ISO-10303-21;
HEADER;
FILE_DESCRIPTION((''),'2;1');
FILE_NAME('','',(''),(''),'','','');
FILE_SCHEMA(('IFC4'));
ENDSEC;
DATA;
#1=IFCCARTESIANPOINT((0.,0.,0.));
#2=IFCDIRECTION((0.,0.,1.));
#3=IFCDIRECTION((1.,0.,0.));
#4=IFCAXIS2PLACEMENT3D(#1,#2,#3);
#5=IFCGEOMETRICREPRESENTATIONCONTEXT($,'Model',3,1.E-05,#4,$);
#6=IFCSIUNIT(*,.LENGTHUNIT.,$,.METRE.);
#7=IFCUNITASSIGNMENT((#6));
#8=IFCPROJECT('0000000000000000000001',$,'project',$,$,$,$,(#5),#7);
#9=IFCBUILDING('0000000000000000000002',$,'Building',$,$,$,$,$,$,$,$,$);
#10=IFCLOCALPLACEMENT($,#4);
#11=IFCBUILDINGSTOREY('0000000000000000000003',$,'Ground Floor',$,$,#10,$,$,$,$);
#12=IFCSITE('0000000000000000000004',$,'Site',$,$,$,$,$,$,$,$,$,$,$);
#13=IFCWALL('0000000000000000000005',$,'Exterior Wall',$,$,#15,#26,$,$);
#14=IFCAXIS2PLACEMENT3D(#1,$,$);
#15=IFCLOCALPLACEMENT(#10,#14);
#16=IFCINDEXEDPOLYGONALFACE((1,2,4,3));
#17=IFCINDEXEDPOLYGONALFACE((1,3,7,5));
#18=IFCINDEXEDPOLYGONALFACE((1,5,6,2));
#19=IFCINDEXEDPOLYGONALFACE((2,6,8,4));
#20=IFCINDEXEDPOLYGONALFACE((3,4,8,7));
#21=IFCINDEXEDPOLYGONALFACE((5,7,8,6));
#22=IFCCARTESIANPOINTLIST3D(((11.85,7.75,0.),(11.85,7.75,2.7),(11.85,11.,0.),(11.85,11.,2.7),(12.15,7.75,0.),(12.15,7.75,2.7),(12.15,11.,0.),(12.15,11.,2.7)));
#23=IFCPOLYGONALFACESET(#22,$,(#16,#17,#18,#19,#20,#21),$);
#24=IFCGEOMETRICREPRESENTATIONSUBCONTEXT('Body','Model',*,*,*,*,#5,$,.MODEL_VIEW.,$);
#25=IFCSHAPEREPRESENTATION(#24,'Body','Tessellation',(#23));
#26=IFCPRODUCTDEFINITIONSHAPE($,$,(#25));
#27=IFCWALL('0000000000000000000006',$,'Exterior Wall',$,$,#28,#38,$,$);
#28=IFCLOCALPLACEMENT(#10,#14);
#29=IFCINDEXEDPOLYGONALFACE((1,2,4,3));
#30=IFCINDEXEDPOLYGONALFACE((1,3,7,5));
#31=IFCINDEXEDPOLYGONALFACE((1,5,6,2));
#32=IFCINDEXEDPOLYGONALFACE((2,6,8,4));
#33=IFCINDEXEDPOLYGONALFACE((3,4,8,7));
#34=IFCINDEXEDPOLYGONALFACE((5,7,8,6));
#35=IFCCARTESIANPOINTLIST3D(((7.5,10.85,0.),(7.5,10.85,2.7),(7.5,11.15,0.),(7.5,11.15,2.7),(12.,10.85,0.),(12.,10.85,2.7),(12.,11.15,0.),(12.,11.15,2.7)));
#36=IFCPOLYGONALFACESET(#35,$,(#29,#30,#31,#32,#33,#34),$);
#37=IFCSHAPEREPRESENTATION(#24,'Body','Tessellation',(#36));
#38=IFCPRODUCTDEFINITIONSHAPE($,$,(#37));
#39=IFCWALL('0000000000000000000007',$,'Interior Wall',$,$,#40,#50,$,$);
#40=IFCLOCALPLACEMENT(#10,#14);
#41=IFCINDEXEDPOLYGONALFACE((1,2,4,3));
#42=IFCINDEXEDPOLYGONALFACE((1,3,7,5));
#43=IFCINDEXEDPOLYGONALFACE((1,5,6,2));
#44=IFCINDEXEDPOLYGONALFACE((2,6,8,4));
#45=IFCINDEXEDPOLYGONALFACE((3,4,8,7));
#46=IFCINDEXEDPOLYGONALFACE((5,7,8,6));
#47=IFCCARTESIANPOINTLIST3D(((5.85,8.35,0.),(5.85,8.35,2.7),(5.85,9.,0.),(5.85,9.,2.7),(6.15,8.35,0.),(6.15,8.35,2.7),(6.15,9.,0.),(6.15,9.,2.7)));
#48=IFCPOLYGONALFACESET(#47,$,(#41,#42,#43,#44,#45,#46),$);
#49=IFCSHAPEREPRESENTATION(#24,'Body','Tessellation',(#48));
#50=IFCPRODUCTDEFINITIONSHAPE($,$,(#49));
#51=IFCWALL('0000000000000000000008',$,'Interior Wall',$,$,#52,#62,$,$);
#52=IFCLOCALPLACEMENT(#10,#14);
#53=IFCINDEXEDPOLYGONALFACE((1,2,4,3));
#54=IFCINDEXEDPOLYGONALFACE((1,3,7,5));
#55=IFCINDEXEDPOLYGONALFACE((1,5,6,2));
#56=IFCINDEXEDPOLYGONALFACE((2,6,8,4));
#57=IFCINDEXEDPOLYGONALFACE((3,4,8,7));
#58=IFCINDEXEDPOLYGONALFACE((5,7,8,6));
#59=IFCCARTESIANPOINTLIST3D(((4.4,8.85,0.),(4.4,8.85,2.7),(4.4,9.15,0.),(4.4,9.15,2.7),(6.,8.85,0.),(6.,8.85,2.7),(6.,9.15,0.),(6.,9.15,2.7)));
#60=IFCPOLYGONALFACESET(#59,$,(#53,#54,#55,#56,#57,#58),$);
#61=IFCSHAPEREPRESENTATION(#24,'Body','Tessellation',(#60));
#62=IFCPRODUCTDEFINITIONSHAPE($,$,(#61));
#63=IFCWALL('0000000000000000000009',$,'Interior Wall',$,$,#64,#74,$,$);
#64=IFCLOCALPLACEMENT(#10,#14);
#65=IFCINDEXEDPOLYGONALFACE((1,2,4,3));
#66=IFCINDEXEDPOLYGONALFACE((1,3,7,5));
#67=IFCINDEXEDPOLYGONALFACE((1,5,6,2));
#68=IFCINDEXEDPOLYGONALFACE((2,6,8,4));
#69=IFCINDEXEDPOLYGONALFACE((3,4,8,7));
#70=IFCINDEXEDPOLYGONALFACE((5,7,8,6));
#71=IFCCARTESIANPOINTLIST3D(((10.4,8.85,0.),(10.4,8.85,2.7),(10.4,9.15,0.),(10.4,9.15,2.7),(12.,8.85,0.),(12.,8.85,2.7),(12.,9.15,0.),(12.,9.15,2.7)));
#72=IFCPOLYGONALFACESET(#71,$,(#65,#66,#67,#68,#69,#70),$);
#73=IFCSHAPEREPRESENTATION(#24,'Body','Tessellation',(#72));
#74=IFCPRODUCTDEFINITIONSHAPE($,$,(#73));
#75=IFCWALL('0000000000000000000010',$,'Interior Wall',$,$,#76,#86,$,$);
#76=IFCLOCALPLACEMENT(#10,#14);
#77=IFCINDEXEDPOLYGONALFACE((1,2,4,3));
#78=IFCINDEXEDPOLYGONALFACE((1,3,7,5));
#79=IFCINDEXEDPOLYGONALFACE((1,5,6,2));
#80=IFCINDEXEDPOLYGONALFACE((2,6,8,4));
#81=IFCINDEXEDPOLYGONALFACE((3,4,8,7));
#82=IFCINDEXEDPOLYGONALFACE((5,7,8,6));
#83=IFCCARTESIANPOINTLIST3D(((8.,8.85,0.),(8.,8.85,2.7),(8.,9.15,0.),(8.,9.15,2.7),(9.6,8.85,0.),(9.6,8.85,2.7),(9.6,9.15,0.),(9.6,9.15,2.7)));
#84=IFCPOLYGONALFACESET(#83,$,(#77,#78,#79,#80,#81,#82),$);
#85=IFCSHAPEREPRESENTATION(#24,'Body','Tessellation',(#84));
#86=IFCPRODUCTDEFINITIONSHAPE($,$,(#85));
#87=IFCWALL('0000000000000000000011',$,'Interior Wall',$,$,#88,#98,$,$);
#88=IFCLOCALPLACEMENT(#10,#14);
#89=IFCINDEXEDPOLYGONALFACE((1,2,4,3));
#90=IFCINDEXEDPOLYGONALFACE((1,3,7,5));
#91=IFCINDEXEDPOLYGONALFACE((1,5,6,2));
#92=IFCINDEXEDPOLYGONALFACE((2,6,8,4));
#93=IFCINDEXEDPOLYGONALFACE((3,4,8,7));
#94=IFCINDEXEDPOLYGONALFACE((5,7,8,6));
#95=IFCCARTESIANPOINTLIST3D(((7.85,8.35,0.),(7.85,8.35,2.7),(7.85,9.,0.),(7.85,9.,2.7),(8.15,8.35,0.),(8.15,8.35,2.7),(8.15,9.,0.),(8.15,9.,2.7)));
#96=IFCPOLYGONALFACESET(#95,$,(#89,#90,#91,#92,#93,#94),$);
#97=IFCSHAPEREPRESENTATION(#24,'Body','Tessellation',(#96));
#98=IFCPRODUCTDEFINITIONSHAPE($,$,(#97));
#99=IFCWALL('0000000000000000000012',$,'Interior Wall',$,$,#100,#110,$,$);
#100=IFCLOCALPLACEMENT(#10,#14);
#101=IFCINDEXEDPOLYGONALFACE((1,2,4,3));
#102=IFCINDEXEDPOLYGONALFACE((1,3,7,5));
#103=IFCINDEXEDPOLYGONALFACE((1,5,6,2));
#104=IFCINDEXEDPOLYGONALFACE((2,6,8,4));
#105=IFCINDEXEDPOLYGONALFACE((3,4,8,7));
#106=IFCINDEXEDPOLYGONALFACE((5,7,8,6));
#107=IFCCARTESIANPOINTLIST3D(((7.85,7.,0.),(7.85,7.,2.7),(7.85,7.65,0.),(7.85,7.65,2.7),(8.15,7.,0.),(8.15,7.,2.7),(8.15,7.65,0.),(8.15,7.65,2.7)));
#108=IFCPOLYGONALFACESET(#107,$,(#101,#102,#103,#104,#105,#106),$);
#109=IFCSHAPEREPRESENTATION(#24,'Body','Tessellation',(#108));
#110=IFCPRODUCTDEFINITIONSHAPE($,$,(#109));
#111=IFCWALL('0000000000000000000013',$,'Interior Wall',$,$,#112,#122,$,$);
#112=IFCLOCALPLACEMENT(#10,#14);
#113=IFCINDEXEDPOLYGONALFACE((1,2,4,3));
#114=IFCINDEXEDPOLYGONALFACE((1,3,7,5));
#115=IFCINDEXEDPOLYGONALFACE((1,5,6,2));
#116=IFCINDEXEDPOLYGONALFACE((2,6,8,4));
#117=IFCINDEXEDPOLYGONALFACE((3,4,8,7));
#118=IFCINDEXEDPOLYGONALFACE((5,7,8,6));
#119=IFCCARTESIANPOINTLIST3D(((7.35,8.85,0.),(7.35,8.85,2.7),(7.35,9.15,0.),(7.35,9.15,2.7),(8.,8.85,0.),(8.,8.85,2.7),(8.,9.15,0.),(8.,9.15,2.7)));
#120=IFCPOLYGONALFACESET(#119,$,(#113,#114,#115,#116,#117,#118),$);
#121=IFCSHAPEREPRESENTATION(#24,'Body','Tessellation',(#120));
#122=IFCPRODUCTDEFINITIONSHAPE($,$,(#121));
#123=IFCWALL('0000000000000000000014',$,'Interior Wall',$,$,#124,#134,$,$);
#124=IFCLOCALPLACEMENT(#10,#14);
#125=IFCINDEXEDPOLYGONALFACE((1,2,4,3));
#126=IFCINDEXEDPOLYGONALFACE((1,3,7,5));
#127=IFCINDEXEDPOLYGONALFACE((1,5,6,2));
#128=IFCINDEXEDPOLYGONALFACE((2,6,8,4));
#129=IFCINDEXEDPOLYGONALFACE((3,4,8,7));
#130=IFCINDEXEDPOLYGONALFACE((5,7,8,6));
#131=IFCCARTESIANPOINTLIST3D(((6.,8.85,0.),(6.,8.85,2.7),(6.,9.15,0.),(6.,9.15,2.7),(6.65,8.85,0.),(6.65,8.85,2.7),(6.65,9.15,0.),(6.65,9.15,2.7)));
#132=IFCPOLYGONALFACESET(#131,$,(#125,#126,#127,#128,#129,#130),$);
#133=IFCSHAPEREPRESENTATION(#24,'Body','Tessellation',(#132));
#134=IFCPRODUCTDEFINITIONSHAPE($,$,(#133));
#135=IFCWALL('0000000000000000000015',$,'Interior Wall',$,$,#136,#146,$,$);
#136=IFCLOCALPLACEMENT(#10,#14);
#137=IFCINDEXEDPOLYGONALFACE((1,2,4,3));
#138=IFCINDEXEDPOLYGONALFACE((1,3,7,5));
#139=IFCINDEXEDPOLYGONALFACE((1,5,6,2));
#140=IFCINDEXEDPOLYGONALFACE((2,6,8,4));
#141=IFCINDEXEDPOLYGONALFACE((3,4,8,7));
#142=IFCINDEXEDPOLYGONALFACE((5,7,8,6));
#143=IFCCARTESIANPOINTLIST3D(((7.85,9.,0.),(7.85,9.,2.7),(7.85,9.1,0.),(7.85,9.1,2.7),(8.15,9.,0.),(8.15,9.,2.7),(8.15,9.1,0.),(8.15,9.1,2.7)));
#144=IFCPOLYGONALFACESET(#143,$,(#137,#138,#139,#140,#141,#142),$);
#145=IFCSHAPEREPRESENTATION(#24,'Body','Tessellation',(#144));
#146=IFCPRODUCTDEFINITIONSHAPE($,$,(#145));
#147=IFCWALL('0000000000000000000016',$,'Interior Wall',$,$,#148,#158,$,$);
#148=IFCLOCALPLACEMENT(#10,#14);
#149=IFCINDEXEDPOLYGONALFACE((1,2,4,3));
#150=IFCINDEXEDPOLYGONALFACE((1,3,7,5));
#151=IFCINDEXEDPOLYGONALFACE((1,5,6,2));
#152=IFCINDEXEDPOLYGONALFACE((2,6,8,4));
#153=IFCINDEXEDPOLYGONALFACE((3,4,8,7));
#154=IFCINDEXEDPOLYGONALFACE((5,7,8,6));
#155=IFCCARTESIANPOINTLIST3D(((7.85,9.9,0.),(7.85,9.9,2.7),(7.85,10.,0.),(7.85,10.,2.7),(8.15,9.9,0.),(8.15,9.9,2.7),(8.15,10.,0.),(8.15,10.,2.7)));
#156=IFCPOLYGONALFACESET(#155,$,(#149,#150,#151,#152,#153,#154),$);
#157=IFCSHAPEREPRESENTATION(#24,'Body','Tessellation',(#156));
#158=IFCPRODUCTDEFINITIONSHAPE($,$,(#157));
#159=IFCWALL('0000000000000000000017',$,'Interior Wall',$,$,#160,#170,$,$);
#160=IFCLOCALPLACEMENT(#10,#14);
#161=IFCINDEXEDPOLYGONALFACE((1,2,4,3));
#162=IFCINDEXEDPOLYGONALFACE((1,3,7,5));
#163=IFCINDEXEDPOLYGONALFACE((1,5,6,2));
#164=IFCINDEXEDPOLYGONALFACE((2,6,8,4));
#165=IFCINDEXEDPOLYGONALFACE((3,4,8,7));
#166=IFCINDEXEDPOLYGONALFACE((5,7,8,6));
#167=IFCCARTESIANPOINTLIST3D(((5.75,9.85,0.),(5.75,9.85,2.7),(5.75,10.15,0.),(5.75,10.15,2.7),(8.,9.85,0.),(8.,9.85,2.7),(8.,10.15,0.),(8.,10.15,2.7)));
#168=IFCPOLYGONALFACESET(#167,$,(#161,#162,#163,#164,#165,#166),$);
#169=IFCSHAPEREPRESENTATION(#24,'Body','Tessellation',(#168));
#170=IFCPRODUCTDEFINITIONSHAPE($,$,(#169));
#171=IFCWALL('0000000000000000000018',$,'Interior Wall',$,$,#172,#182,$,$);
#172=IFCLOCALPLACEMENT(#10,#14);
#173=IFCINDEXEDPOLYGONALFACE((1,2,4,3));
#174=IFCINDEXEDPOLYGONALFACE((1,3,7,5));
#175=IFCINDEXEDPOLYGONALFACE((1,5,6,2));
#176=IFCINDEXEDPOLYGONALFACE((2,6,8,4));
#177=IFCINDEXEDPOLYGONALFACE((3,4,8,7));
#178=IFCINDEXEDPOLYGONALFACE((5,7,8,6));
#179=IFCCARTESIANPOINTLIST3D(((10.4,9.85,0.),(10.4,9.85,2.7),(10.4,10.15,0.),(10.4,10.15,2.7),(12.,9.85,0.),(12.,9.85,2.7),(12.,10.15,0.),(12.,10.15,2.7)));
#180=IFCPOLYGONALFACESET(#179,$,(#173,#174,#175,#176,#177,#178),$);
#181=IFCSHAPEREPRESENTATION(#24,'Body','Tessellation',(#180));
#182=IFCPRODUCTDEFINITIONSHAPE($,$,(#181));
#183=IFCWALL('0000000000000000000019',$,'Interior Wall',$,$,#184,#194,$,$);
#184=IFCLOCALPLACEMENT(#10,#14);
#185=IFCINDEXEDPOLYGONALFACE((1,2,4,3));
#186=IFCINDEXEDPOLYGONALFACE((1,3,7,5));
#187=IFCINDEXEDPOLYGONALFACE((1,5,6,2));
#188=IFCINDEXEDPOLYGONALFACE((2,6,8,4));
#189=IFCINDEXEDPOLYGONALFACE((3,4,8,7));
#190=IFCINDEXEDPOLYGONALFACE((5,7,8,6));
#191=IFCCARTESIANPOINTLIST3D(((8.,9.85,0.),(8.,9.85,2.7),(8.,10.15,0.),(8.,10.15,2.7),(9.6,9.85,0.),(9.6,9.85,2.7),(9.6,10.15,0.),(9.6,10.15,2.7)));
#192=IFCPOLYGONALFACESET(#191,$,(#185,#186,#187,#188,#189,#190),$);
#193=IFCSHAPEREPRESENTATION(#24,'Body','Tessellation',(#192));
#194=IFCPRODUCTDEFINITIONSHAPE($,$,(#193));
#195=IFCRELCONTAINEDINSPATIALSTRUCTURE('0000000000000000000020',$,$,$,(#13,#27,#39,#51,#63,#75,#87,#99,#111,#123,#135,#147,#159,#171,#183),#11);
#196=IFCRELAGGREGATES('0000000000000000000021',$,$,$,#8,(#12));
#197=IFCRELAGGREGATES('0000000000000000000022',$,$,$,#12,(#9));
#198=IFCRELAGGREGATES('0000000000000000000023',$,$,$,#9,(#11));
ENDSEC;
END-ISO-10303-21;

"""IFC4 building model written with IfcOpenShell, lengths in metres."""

from ifc_helpers import new_model, si_unit, frame, origin_with_axes, place, context, subcontext, project, spatial, indexed_curve, outline, extrude, element, save


model = new_model("IFC4")

# Units and contexts
model_context = context("Model", 3, precision=1e-05, world=origin_with_axes())
body_context = subcontext(model_context, "Body", "Model", "MODEL_VIEW")
ifc_project = project(units=[si_unit("LENGTHUNIT", "METRE")], contexts=[model_context])

# Site, building, storey
site = spatial("IfcSite", under=ifc_project, Name="Site")
building = spatial("IfcBuilding", under=site, Name="Building")
storey_placement = place(None, origin_with_axes())
storey = spatial("IfcBuildingStorey", under=building, at=storey_placement, Name="Ground Floor")

# Walls
wall_1_placement = place(storey_placement, frame((12.0, 7.75, 0.0), z_axis=(0.0, 0.0, 1.0), x_axis=(0.0, 1.0, 0.0)))
element("IfcWall", 1, at=wall_1_placement, inside=storey, Name="Exterior Wall", context=body_context, shape_type="SweptSolid", body=[
    extrude(outline(indexed_curve([(0.0, 0.0), (0.0, 0.3), (3.25, 0.3), (3.25, 0.0), (0.0, 0.0)], self_intersect=False)), frame((0.0, -0.15, 0.0), z_axis=(0.0, 0.0, 1.0), x_axis=(1.0, 0.0, 0.0)), (0.0, 0.0, 1.0), 2.7),
])
wall_2_placement = place(storey_placement, frame((12.0, 11.0, 0.0), z_axis=(0.0, 0.0, 1.0), x_axis=(-1.0, 0.0, 0.0)))
element("IfcWall", 2, at=wall_2_placement, inside=storey, Name="Exterior Wall", context=body_context, shape_type="SweptSolid", body=[
    extrude(outline(indexed_curve([(0.0, 0.0), (0.0, 0.3), (4.5, 0.3), (4.5, 0.0), (0.0, 0.0)], self_intersect=False)), frame((0.0, -0.15, 0.0), z_axis=(0.0, 0.0, 1.0), x_axis=(1.0, 0.0, 0.0)), (0.0, 0.0, 1.0), 2.7),
])
wall_3_placement = place(storey_placement, frame((6.0, 8.35, 0.0), z_axis=(0.0, 0.0, 1.0), x_axis=(0.0, 1.0, 0.0)))
element("IfcWall", 3, at=wall_3_placement, inside=storey, Name="Interior Wall", context=body_context, shape_type="SweptSolid", body=[
    extrude(outline(indexed_curve([(0.0, 0.0), (0.0, 0.3), (0.65, 0.3), (0.65, 0.0), (0.0, 0.0)], self_intersect=False)), frame((0.0, -0.15, 0.0), z_axis=(0.0, 0.0, 1.0), x_axis=(1.0, 0.0, 0.0)), (0.0, 0.0, 1.0), 2.7),
])
for number, where, z_axis, x_axis, name in (
    (4, (6.0, 9.0, 0.0), (0.0, 0.0, 1.0), (-1.0, 0.0, 0.0), "Interior Wall"),
    (5, (12.0, 9.0, 0.0), (0.0, 0.0, 1.0), (-1.0, 0.0, 0.0), "Interior Wall"),
    (6, (9.6, 9.0, 0.0), (0.0, 0.0, 1.0), (-1.0, 0.0, 0.0), "Interior Wall"),
):
    element("IfcWall", number, at=place(storey_placement, frame(where, z_axis=z_axis, x_axis=x_axis)), inside=storey, Name=name, context=body_context, shape_type="SweptSolid", body=[
        extrude(outline(indexed_curve([(0.0, 0.0), (0.0, 0.3), (1.6, 0.3), (1.6, 0.0), (0.0, 0.0)], self_intersect=False)), frame((0.0, -0.15, 0.0), z_axis=(0.0, 0.0, 1.0), x_axis=(1.0, 0.0, 0.0)), (0.0, 0.0, 1.0), 2.7),
    ])
for number, where, z_axis, x_axis, name in (
    (7, (8.0, 9.0, 0.0), (0.0, 0.0, 1.0), (0.0, -1.0, 0.0), "Interior Wall"),
    (8, (8.0, 7.65, 0.0), (0.0, 0.0, 1.0), (0.0, -1.0, 0.0), "Interior Wall"),
    (9, (8.0, 9.0, 0.0), (0.0, 0.0, 1.0), (-1.0, 0.0, 0.0), "Interior Wall"),
    (10, (6.65, 9.0, 0.0), (0.0, 0.0, 1.0), (-1.0, 0.0, 0.0), "Interior Wall"),
):
    element("IfcWall", number, at=place(storey_placement, frame(where, z_axis=z_axis, x_axis=x_axis)), inside=storey, Name=name, context=body_context, shape_type="SweptSolid", body=[
        extrude(outline(indexed_curve([(0.0, 0.0), (0.0, 0.3), (0.65, 0.3), (0.65, 0.0), (0.0, 0.0)], self_intersect=False)), frame((0.0, -0.15, 0.0), z_axis=(0.0, 0.0, 1.0), x_axis=(1.0, 0.0, 0.0)), (0.0, 0.0, 1.0), 2.7),
    ])
for number, where, z_axis, x_axis, name in (
    (11, (8.0, 9.0, 0.0), (0.0, 0.0, 1.0), (0.0, 1.0, 0.0), "Interior Wall"),
    (12, (8.0, 9.9, 0.0), (0.0, 0.0, 1.0), (0.0, 1.0, 0.0), "Interior Wall"),
):
    element("IfcWall", number, at=place(storey_placement, frame(where, z_axis=z_axis, x_axis=x_axis)), inside=storey, Name=name, context=body_context, shape_type="SweptSolid", body=[
        extrude(outline(indexed_curve([(0.0, 0.0), (0.0, 0.3), (0.1, 0.3), (0.1, 0.0), (0.0, 0.0)], self_intersect=False)), frame((0.0, -0.15, 0.0), z_axis=(0.0, 0.0, 1.0), x_axis=(1.0, 0.0, 0.0)), (0.0, 0.0, 1.0), 2.7),
    ])
wall_4_placement = place(storey_placement, frame((8.0, 10.0, 0.0), z_axis=(0.0, 0.0, 1.0), x_axis=(-1.0, 0.0, 0.0)))
element("IfcWall", 13, at=wall_4_placement, inside=storey, Name="Interior Wall", context=body_context, shape_type="SweptSolid", body=[
    extrude(outline(indexed_curve([(0.0, 0.0), (0.0, 0.3), (2.25, 0.3), (2.25, 0.0), (0.0, 0.0)], self_intersect=False)), frame((0.0, -0.15, 0.0), z_axis=(0.0, 0.0, 1.0), x_axis=(1.0, 0.0, 0.0)), (0.0, 0.0, 1.0), 2.7),
])
for number, where, z_axis, x_axis, name in (
    (14, (12.0, 10.0, 0.0), (0.0, 0.0, 1.0), (-1.0, 0.0, 0.0), "Interior Wall"),
    (15, (9.6, 10.0, 0.0), (0.0, 0.0, 1.0), (-1.0, 0.0, 0.0), "Interior Wall"),
):
    element("IfcWall", number, at=place(storey_placement, frame(where, z_axis=z_axis, x_axis=x_axis)), inside=storey, Name=name, context=body_context, shape_type="SweptSolid", body=[
        extrude(outline(indexed_curve([(0.0, 0.0), (0.0, 0.3), (1.6, 0.3), (1.6, 0.0), (0.0, 0.0)], self_intersect=False)), frame((0.0, -0.15, 0.0), z_axis=(0.0, 0.0, 1.0), x_axis=(1.0, 0.0, 0.0)), (0.0, 0.0, 1.0), 2.7),
    ])

save(model, "model.ifc")
